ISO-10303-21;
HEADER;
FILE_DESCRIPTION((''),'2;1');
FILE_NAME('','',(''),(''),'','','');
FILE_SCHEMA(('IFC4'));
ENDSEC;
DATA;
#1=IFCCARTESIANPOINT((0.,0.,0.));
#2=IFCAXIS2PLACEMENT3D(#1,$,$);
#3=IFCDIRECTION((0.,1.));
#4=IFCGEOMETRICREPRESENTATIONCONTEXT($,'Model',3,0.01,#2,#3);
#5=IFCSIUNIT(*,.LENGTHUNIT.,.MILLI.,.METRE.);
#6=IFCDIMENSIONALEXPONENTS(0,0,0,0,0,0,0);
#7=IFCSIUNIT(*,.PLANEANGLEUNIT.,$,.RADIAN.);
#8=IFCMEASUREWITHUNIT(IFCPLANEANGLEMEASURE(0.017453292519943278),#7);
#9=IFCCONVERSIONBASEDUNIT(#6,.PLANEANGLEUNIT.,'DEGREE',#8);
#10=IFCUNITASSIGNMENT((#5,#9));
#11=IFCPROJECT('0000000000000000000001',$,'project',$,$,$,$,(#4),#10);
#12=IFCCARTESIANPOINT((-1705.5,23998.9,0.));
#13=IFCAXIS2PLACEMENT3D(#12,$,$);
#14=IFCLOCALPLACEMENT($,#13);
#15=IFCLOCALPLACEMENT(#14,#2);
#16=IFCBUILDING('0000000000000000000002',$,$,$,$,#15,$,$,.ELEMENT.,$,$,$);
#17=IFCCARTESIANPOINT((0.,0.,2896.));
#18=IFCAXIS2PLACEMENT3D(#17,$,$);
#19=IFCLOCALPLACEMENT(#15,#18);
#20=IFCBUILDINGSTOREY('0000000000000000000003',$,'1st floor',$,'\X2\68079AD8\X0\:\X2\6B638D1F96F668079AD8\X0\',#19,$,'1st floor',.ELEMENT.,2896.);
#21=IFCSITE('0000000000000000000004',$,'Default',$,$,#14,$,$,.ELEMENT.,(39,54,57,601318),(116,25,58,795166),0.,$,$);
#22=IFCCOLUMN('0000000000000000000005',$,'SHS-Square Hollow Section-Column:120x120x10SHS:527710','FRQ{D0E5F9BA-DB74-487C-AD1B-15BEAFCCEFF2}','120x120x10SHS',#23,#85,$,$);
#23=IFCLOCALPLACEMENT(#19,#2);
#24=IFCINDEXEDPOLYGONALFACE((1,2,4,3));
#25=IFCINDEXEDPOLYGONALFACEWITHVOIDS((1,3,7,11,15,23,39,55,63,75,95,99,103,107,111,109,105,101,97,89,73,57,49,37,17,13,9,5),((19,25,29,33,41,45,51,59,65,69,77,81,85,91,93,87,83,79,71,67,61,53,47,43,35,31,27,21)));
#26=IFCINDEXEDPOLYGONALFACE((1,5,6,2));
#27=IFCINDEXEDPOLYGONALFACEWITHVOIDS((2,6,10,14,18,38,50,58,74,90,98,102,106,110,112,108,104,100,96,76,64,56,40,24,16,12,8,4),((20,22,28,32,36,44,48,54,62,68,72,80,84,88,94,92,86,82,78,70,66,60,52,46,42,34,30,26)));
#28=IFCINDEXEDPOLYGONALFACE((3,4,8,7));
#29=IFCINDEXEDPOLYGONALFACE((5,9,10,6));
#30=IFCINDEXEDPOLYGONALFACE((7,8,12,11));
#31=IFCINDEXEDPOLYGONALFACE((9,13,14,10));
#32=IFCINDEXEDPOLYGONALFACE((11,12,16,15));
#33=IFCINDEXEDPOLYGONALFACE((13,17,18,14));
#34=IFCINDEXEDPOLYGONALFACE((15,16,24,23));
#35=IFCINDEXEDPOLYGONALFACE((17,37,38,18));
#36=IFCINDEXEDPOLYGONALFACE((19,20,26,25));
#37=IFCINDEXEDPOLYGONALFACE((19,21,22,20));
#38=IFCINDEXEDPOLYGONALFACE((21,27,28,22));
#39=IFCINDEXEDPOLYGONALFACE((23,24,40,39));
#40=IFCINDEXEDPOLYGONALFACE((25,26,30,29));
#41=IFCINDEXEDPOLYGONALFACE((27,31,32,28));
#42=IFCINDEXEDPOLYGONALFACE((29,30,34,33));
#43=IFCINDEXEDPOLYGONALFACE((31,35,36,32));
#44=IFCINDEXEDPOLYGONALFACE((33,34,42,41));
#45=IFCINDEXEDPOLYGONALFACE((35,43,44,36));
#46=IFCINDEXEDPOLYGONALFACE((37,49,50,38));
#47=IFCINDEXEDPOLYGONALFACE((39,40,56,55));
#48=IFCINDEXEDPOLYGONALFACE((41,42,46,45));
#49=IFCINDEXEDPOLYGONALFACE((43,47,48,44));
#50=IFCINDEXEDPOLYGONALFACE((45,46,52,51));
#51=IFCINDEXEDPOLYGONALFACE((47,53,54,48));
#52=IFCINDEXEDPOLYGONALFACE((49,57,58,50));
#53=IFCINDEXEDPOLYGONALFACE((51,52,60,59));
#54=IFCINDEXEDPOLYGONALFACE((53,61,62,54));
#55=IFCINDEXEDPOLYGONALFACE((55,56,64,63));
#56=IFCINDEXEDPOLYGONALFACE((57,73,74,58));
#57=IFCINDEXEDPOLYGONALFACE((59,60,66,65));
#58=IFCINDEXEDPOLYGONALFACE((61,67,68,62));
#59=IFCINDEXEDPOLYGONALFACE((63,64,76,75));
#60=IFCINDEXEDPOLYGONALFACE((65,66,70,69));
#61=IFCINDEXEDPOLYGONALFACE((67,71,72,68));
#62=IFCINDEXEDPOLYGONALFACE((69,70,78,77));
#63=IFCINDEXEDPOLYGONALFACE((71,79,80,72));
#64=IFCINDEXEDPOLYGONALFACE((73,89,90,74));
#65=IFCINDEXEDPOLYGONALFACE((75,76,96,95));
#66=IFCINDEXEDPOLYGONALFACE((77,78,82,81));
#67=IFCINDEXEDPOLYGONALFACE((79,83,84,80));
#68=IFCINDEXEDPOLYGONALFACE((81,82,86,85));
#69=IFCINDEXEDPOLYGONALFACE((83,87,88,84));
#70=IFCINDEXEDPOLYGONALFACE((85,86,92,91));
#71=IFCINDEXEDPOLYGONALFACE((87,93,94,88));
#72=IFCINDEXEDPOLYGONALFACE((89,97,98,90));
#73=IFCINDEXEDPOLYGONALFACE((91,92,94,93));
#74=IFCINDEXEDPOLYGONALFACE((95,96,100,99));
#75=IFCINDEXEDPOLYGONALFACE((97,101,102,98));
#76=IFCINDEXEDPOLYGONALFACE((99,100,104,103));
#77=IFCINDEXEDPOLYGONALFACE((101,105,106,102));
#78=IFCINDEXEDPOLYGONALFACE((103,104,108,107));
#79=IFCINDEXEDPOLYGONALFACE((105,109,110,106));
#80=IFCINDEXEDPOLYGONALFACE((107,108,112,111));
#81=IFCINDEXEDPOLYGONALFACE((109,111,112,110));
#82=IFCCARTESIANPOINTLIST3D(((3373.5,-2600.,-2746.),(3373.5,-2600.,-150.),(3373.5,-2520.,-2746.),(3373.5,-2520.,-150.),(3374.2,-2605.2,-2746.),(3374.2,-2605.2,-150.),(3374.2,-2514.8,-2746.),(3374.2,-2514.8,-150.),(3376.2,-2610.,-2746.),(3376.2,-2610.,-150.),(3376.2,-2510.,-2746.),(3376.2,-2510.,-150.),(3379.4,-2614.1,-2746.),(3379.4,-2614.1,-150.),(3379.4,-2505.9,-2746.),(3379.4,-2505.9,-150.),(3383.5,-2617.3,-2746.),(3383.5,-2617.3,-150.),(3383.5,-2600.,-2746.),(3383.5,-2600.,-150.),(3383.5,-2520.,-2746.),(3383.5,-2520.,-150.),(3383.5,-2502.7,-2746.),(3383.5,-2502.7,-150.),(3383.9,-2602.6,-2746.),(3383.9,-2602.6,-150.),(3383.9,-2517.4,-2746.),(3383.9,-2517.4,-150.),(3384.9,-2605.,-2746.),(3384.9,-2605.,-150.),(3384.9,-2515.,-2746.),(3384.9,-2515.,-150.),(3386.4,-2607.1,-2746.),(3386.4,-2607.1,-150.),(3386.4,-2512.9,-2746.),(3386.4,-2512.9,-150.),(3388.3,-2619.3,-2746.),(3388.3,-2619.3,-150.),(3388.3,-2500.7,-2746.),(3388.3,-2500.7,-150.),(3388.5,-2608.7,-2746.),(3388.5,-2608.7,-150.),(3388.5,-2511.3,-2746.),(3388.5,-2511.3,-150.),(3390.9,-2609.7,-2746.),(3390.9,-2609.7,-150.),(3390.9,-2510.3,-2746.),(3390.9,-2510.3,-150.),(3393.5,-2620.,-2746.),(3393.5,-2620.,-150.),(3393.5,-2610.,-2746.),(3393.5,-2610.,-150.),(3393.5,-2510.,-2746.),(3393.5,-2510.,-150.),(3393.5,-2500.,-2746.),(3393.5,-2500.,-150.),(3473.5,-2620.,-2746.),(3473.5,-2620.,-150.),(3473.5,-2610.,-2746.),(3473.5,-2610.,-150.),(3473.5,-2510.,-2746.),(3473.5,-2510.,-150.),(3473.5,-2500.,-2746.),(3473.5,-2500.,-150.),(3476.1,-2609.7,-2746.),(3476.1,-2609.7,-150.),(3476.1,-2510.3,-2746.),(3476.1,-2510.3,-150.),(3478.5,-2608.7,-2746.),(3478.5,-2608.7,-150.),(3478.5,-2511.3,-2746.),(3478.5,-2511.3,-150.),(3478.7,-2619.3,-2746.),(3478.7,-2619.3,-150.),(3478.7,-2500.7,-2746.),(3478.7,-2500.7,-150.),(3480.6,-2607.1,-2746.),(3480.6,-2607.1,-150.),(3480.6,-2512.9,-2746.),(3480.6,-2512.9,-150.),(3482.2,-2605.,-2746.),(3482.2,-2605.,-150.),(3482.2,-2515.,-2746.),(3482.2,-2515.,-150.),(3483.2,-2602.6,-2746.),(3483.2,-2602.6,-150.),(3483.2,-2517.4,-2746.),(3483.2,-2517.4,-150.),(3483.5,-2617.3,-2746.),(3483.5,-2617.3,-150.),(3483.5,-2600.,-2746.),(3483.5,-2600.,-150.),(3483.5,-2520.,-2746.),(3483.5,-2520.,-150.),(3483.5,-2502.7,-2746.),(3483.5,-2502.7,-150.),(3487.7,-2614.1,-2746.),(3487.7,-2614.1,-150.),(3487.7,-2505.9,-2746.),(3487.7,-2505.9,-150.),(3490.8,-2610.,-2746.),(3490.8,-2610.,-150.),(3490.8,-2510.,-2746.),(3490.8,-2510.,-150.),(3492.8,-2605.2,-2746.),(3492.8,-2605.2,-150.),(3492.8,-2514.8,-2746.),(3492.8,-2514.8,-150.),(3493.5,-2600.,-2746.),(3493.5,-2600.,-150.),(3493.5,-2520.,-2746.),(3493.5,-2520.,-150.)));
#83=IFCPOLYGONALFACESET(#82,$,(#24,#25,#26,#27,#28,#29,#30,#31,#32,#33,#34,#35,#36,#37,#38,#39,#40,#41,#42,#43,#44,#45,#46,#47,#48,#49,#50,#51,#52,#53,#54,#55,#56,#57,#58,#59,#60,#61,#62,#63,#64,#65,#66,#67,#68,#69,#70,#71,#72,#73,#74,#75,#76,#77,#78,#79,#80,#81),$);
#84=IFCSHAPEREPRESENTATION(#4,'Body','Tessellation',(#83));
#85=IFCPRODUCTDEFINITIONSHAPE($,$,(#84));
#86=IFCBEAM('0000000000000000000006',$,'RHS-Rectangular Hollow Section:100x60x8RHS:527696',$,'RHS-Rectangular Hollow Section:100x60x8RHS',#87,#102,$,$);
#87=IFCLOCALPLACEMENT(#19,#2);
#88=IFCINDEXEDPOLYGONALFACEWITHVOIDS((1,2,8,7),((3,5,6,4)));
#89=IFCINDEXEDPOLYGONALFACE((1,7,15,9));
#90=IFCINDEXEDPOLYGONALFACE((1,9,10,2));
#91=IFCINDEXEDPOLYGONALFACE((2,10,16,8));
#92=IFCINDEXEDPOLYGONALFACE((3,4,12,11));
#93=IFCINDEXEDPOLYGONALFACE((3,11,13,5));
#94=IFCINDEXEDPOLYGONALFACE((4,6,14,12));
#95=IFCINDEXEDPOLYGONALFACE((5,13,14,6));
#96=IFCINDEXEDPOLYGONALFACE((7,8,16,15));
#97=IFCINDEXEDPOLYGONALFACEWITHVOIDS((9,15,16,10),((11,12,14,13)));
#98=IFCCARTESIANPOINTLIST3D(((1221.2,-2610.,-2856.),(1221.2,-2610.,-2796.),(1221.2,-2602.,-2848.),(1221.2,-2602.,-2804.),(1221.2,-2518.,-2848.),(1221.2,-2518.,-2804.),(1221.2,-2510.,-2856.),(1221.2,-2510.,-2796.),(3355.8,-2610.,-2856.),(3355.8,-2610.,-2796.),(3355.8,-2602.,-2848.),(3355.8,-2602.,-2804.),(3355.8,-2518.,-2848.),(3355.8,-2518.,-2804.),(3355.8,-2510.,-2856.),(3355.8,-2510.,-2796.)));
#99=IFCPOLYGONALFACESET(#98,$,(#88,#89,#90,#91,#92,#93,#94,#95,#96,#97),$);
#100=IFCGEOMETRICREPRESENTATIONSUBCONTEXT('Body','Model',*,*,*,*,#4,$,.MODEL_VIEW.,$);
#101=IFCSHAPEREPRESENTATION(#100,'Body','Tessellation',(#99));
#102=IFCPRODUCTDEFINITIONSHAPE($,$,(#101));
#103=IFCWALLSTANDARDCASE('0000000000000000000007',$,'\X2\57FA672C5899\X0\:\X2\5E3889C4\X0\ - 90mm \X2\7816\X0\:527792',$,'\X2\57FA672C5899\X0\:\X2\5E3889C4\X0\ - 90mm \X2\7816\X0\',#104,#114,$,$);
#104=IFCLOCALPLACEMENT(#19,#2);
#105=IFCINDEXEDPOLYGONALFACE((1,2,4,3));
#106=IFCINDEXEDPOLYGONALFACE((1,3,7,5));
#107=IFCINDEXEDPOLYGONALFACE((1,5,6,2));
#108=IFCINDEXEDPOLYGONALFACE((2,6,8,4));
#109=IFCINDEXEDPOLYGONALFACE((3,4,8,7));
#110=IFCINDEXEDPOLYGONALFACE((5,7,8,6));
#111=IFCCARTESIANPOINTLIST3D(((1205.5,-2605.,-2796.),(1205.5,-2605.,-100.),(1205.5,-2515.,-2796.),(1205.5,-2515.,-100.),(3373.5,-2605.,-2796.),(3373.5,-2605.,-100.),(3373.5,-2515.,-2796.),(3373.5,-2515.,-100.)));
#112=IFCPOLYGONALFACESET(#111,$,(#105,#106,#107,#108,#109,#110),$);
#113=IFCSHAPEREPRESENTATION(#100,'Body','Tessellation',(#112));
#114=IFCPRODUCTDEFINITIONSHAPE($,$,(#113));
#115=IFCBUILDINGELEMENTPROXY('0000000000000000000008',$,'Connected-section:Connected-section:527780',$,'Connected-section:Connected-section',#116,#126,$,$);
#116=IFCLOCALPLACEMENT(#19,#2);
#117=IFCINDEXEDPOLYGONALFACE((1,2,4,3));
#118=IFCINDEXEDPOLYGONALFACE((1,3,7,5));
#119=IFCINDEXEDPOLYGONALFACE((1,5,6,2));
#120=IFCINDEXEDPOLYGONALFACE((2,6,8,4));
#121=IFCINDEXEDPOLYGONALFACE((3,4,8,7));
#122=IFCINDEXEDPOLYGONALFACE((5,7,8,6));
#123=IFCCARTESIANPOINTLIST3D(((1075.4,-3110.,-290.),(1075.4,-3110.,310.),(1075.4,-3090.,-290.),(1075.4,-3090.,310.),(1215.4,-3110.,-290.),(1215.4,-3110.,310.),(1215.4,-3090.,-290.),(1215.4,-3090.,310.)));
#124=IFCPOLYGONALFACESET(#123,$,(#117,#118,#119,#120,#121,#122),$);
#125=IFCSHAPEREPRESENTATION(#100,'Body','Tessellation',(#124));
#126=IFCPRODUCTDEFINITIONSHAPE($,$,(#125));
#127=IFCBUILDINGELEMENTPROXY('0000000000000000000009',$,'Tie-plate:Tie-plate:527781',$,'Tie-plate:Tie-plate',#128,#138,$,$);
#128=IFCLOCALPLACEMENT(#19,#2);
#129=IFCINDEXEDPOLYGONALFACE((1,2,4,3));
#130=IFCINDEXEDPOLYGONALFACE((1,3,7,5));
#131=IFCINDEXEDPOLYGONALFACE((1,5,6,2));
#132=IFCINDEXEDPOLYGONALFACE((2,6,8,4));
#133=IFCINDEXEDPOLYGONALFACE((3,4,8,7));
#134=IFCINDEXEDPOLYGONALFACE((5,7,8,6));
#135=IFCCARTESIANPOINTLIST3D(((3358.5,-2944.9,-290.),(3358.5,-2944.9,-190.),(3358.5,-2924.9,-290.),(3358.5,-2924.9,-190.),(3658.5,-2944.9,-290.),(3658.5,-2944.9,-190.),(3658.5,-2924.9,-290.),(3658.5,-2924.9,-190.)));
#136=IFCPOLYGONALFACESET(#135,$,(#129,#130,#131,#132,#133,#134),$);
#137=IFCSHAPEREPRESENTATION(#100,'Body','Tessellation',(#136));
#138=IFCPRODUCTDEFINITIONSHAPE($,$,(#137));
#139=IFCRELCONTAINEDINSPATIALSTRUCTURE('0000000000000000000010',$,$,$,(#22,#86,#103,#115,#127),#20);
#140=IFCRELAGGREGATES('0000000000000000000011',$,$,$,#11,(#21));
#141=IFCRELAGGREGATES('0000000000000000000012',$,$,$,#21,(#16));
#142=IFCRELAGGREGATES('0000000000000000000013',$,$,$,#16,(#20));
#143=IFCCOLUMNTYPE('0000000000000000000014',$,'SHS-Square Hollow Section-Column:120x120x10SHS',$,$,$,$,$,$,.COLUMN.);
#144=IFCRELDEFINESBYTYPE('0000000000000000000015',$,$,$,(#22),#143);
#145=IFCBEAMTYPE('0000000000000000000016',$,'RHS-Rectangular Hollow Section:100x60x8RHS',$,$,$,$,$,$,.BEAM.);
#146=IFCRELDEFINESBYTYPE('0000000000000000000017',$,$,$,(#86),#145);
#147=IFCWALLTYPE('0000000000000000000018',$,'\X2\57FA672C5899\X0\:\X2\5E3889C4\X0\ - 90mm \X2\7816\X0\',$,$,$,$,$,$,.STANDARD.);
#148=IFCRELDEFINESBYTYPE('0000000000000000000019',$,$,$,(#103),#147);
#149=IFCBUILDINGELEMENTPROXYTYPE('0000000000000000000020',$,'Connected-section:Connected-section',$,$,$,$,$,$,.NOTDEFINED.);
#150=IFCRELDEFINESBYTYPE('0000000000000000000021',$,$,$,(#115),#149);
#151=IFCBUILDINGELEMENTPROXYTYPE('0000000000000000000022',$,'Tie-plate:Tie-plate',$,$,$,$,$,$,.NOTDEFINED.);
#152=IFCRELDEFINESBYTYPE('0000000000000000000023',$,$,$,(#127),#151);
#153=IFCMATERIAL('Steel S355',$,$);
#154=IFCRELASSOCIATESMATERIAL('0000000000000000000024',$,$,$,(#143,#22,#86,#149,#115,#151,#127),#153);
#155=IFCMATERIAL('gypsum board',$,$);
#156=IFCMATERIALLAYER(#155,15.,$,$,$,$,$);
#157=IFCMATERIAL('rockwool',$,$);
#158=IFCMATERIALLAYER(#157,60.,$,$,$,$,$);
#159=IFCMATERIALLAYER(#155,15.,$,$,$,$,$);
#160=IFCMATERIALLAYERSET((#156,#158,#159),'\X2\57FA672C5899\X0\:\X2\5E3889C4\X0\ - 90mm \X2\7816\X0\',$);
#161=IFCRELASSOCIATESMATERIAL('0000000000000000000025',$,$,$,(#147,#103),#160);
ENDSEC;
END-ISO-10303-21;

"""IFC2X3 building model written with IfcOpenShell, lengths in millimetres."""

from ifc_helpers import new_model, entity, si_unit, converted_unit, direction, frame, frame_2d, origin, origin_2d, place, context, subcontext, project, spatial, rectangle, hollow_rectangle, extrude, boolean, clip, halfspace, source, transform, mapped, material, layer, layer_set, layer_usage, type_object, type_shapes, element, save


model = new_model("IFC2X3")

# Units and contexts
model_context = context("Model", 3, precision=0.01, world=origin(), true_north=direction((0.0, 1.0)))
body_context = subcontext(model_context, "Body", "Model", "MODEL_VIEW")
ifc_project = project(units=[si_unit("LENGTHUNIT", "METRE", prefix="MILLI"), converted_unit("PLANEANGLEUNIT", "DEGREE", entity("IfcPlaneAngleMeasure", 0.017453292519943278), si_unit("PLANEANGLEUNIT", "RADIAN"), dimensions=[0, 0, 0, 0, 0, 0, 0])], contexts=[model_context])

# Site, building, storey
site_placement = place(None, frame((-1705.5, 23998.9, 0.0)))
site = spatial("IfcSite", under=ifc_project, at=site_placement, Name="Default", CompositionType="ELEMENT", RefLatitude=(39, 54, 57, 601318), RefLongitude=(116, 25, 58, 795166), RefElevation=0.0)
building_placement = place(site_placement, origin())
building = spatial("IfcBuilding", under=site, at=building_placement, CompositionType="ELEMENT")
storey_placement = place(building_placement, frame((0.0, 0.0, 2896.0)))
storey = spatial("IfcBuildingStorey", under=building, at=storey_placement, Name="1st floor", ObjectType="标高:正负零标高", LongName="1st floor", CompositionType="ELEMENT", Elevation=2896.0)

# Column
ifc_material_1 = material(Name="Steel S355")
column_type_1 = type_object("IfcColumnType", Name="SHS-Square Hollow Section-Column:120x120x10SHS", PredefinedType="COLUMN", material=ifc_material_1)
column_1_placement = place(storey_placement, frame((3433.5, -2560.0, -150.0), z_axis=(0.0, 0.0, 1.0), x_axis=(0.0, -1.0, 0.0)))
element("IfcColumn", 1, at=column_1_placement, inside=storey, type_object=column_type_1, material=ifc_material_1, Name="SHS-Square Hollow Section-Column:120x120x10SHS:527710", Description="FRQ{D0E5F9BA-DB74-487C-AD1B-15BEAFCCEFF2}", ObjectType="120x120x10SHS", context=model_context, shape_type="Clipping", body=[
    clip(extrude(hollow_rectangle(XDim=120.0, YDim=120.0, WallThickness=10.0, InnerFilletRadius=10.0, OuterFilletRadius=20.0, at=origin_2d()), origin(), (0.0, 0.0, -1.0), 2680.9), halfspace(frame((-2560.0, -3433.5, -2596.0), z_axis=(0.0, 0.0, 1.0), x_axis=(0.0, 1.0, 0.0)), True)),
])

# Beam
beam_type_1 = type_object("IfcBeamType", Name="RHS-Rectangular Hollow Section:100x60x8RHS", PredefinedType="BEAM")
beam_1_placement = place(storey_placement, frame((1221.2, -2510.0, -2826.0)))
element("IfcBeam", 2, at=beam_1_placement, inside=storey, type_object=beam_type_1, material=ifc_material_1, Name="RHS-Rectangular Hollow Section:100x60x8RHS:527696", ObjectType="RHS-Rectangular Hollow Section:100x60x8RHS", context=body_context, shape_type="SweptSolid", body=[
    boolean("DIFFERENCE", extrude(rectangle(XDim=60.0, YDim=100.0, at=frame_2d((0.0, 0.0), x_axis=(1.0, 0.0))), frame((0.0, -50.0, 0.0), z_axis=(1.0, 0.0, 0.0), x_axis=(0.0, 0.0, -1.0)), (0.0, 0.0, 1.0), 2134.6), extrude(rectangle(XDim=44.0, YDim=84.0, at=frame_2d((0.0, 0.0), x_axis=(0.0, 1.0))), frame((2134.6, -50.0, 0.0), z_axis=(-1.0, 0.0, 0.0), x_axis=(0.0, 1.0, 0.0)), (0.0, 0.0, 1.0), 2134.6)),
])

# Wall
ifc_material_2 = material(Name="gypsum board")
ifc_layer_1 = layer(ifc_material_2, 15.0)
ifc_material_3 = material(Name="rockwool")
ifc_layer_2 = layer(ifc_material_3, 60.0)
ifc_layer_3 = layer(ifc_material_2, 15.0)
ifc_layer_set = layer_set([ifc_layer_1, ifc_layer_2, ifc_layer_3], Name="基本墙:常规 - 90mm 砖")
ifc_layer_usage = layer_usage(ifc_layer_set, "AXIS2", "NEGATIVE", 45.0)
wall_type = type_object("IfcWallType", Name="基本墙:常规 - 90mm 砖", PredefinedType="STANDARD", material=ifc_layer_set)
wall_placement = place(storey_placement, frame((3373.5, -2560.0, -2796.0), z_axis=(0.0, 0.0, 1.0), x_axis=(-1.0, 0.0, 0.0)))
element("IfcWallStandardCase", 3, at=wall_placement, inside=storey, type_object=wall_type, material=ifc_layer_usage, Name="基本墙:常规 - 90mm 砖:527792", ObjectType="基本墙:常规 - 90mm 砖", context=body_context, shape_type="SweptSolid", body=[
    extrude(rectangle(XDim=2168.0, YDim=90.0, at=frame_2d((1084.0, 0.0), x_axis=(-1.0, 0.0))), origin(), (0.0, 0.0, 1.0), 2696.0),
])

# Building element proxies
building_element_proxy_type_1 = type_object("IfcBuildingElementProxyType", Name="Connected-section:Connected-section", PredefinedType="NOTDEFINED", material=ifc_material_1)
shared_shape_1 = source(origin(), body_context, "Body", "SweptSolid", [
    extrude(rectangle(XDim=20.0, YDim=140.0, at=frame_2d((0.0, 0.0), x_axis=(1.0, 0.0))), frame((70.0, 10.0, 0.0), z_axis=(0.0, 0.0, 1.0), x_axis=(0.0, 1.0, 0.0)), (0.0, 0.0, 1.0), 600.0),
])
type_shapes(building_element_proxy_type_1, [shared_shape_1])
proxy_1_placement = place(storey_placement, frame((1075.4, -3110.0, -290.0)))
element("IfcBuildingElementProxy", 4, at=proxy_1_placement, inside=storey, type_object=building_element_proxy_type_1, material=ifc_material_1, Name="Connected-section:Connected-section:527780", ObjectType="Connected-section:Connected-section", context=body_context, shape_type="MappedRepresentation", body=[
    mapped(shared_shape_1, transform((0.0, 0.0, 0.0), scale=1.0)),
])
building_element_proxy_type_2 = type_object("IfcBuildingElementProxyType", Name="Tie-plate:Tie-plate", PredefinedType="NOTDEFINED", material=ifc_material_1)
shared_shape_2 = source(origin(), body_context, "Body", "SweptSolid", [
    extrude(rectangle(XDim=20.0, YDim=300.0, at=frame_2d((0.0, 0.0), x_axis=(1.0, 0.0))), frame((150.0, 10.0, 0.0), z_axis=(0.0, 0.0, 1.0), x_axis=(0.0, 1.0, 0.0)), (0.0, 0.0, 1.0), 100.0),
])
type_shapes(building_element_proxy_type_2, [shared_shape_2])
proxy_2_placement = place(storey_placement, frame((3358.5, -2944.9, -290.0)))
element("IfcBuildingElementProxy", 5, at=proxy_2_placement, inside=storey, type_object=building_element_proxy_type_2, material=ifc_material_1, Name="Tie-plate:Tie-plate:527781", ObjectType="Tie-plate:Tie-plate", context=body_context, shape_type="MappedRepresentation", body=[
    mapped(shared_shape_2, transform((0.0, 0.0, 0.0), scale=1.0)),
])

save(model, "model.ifc")
